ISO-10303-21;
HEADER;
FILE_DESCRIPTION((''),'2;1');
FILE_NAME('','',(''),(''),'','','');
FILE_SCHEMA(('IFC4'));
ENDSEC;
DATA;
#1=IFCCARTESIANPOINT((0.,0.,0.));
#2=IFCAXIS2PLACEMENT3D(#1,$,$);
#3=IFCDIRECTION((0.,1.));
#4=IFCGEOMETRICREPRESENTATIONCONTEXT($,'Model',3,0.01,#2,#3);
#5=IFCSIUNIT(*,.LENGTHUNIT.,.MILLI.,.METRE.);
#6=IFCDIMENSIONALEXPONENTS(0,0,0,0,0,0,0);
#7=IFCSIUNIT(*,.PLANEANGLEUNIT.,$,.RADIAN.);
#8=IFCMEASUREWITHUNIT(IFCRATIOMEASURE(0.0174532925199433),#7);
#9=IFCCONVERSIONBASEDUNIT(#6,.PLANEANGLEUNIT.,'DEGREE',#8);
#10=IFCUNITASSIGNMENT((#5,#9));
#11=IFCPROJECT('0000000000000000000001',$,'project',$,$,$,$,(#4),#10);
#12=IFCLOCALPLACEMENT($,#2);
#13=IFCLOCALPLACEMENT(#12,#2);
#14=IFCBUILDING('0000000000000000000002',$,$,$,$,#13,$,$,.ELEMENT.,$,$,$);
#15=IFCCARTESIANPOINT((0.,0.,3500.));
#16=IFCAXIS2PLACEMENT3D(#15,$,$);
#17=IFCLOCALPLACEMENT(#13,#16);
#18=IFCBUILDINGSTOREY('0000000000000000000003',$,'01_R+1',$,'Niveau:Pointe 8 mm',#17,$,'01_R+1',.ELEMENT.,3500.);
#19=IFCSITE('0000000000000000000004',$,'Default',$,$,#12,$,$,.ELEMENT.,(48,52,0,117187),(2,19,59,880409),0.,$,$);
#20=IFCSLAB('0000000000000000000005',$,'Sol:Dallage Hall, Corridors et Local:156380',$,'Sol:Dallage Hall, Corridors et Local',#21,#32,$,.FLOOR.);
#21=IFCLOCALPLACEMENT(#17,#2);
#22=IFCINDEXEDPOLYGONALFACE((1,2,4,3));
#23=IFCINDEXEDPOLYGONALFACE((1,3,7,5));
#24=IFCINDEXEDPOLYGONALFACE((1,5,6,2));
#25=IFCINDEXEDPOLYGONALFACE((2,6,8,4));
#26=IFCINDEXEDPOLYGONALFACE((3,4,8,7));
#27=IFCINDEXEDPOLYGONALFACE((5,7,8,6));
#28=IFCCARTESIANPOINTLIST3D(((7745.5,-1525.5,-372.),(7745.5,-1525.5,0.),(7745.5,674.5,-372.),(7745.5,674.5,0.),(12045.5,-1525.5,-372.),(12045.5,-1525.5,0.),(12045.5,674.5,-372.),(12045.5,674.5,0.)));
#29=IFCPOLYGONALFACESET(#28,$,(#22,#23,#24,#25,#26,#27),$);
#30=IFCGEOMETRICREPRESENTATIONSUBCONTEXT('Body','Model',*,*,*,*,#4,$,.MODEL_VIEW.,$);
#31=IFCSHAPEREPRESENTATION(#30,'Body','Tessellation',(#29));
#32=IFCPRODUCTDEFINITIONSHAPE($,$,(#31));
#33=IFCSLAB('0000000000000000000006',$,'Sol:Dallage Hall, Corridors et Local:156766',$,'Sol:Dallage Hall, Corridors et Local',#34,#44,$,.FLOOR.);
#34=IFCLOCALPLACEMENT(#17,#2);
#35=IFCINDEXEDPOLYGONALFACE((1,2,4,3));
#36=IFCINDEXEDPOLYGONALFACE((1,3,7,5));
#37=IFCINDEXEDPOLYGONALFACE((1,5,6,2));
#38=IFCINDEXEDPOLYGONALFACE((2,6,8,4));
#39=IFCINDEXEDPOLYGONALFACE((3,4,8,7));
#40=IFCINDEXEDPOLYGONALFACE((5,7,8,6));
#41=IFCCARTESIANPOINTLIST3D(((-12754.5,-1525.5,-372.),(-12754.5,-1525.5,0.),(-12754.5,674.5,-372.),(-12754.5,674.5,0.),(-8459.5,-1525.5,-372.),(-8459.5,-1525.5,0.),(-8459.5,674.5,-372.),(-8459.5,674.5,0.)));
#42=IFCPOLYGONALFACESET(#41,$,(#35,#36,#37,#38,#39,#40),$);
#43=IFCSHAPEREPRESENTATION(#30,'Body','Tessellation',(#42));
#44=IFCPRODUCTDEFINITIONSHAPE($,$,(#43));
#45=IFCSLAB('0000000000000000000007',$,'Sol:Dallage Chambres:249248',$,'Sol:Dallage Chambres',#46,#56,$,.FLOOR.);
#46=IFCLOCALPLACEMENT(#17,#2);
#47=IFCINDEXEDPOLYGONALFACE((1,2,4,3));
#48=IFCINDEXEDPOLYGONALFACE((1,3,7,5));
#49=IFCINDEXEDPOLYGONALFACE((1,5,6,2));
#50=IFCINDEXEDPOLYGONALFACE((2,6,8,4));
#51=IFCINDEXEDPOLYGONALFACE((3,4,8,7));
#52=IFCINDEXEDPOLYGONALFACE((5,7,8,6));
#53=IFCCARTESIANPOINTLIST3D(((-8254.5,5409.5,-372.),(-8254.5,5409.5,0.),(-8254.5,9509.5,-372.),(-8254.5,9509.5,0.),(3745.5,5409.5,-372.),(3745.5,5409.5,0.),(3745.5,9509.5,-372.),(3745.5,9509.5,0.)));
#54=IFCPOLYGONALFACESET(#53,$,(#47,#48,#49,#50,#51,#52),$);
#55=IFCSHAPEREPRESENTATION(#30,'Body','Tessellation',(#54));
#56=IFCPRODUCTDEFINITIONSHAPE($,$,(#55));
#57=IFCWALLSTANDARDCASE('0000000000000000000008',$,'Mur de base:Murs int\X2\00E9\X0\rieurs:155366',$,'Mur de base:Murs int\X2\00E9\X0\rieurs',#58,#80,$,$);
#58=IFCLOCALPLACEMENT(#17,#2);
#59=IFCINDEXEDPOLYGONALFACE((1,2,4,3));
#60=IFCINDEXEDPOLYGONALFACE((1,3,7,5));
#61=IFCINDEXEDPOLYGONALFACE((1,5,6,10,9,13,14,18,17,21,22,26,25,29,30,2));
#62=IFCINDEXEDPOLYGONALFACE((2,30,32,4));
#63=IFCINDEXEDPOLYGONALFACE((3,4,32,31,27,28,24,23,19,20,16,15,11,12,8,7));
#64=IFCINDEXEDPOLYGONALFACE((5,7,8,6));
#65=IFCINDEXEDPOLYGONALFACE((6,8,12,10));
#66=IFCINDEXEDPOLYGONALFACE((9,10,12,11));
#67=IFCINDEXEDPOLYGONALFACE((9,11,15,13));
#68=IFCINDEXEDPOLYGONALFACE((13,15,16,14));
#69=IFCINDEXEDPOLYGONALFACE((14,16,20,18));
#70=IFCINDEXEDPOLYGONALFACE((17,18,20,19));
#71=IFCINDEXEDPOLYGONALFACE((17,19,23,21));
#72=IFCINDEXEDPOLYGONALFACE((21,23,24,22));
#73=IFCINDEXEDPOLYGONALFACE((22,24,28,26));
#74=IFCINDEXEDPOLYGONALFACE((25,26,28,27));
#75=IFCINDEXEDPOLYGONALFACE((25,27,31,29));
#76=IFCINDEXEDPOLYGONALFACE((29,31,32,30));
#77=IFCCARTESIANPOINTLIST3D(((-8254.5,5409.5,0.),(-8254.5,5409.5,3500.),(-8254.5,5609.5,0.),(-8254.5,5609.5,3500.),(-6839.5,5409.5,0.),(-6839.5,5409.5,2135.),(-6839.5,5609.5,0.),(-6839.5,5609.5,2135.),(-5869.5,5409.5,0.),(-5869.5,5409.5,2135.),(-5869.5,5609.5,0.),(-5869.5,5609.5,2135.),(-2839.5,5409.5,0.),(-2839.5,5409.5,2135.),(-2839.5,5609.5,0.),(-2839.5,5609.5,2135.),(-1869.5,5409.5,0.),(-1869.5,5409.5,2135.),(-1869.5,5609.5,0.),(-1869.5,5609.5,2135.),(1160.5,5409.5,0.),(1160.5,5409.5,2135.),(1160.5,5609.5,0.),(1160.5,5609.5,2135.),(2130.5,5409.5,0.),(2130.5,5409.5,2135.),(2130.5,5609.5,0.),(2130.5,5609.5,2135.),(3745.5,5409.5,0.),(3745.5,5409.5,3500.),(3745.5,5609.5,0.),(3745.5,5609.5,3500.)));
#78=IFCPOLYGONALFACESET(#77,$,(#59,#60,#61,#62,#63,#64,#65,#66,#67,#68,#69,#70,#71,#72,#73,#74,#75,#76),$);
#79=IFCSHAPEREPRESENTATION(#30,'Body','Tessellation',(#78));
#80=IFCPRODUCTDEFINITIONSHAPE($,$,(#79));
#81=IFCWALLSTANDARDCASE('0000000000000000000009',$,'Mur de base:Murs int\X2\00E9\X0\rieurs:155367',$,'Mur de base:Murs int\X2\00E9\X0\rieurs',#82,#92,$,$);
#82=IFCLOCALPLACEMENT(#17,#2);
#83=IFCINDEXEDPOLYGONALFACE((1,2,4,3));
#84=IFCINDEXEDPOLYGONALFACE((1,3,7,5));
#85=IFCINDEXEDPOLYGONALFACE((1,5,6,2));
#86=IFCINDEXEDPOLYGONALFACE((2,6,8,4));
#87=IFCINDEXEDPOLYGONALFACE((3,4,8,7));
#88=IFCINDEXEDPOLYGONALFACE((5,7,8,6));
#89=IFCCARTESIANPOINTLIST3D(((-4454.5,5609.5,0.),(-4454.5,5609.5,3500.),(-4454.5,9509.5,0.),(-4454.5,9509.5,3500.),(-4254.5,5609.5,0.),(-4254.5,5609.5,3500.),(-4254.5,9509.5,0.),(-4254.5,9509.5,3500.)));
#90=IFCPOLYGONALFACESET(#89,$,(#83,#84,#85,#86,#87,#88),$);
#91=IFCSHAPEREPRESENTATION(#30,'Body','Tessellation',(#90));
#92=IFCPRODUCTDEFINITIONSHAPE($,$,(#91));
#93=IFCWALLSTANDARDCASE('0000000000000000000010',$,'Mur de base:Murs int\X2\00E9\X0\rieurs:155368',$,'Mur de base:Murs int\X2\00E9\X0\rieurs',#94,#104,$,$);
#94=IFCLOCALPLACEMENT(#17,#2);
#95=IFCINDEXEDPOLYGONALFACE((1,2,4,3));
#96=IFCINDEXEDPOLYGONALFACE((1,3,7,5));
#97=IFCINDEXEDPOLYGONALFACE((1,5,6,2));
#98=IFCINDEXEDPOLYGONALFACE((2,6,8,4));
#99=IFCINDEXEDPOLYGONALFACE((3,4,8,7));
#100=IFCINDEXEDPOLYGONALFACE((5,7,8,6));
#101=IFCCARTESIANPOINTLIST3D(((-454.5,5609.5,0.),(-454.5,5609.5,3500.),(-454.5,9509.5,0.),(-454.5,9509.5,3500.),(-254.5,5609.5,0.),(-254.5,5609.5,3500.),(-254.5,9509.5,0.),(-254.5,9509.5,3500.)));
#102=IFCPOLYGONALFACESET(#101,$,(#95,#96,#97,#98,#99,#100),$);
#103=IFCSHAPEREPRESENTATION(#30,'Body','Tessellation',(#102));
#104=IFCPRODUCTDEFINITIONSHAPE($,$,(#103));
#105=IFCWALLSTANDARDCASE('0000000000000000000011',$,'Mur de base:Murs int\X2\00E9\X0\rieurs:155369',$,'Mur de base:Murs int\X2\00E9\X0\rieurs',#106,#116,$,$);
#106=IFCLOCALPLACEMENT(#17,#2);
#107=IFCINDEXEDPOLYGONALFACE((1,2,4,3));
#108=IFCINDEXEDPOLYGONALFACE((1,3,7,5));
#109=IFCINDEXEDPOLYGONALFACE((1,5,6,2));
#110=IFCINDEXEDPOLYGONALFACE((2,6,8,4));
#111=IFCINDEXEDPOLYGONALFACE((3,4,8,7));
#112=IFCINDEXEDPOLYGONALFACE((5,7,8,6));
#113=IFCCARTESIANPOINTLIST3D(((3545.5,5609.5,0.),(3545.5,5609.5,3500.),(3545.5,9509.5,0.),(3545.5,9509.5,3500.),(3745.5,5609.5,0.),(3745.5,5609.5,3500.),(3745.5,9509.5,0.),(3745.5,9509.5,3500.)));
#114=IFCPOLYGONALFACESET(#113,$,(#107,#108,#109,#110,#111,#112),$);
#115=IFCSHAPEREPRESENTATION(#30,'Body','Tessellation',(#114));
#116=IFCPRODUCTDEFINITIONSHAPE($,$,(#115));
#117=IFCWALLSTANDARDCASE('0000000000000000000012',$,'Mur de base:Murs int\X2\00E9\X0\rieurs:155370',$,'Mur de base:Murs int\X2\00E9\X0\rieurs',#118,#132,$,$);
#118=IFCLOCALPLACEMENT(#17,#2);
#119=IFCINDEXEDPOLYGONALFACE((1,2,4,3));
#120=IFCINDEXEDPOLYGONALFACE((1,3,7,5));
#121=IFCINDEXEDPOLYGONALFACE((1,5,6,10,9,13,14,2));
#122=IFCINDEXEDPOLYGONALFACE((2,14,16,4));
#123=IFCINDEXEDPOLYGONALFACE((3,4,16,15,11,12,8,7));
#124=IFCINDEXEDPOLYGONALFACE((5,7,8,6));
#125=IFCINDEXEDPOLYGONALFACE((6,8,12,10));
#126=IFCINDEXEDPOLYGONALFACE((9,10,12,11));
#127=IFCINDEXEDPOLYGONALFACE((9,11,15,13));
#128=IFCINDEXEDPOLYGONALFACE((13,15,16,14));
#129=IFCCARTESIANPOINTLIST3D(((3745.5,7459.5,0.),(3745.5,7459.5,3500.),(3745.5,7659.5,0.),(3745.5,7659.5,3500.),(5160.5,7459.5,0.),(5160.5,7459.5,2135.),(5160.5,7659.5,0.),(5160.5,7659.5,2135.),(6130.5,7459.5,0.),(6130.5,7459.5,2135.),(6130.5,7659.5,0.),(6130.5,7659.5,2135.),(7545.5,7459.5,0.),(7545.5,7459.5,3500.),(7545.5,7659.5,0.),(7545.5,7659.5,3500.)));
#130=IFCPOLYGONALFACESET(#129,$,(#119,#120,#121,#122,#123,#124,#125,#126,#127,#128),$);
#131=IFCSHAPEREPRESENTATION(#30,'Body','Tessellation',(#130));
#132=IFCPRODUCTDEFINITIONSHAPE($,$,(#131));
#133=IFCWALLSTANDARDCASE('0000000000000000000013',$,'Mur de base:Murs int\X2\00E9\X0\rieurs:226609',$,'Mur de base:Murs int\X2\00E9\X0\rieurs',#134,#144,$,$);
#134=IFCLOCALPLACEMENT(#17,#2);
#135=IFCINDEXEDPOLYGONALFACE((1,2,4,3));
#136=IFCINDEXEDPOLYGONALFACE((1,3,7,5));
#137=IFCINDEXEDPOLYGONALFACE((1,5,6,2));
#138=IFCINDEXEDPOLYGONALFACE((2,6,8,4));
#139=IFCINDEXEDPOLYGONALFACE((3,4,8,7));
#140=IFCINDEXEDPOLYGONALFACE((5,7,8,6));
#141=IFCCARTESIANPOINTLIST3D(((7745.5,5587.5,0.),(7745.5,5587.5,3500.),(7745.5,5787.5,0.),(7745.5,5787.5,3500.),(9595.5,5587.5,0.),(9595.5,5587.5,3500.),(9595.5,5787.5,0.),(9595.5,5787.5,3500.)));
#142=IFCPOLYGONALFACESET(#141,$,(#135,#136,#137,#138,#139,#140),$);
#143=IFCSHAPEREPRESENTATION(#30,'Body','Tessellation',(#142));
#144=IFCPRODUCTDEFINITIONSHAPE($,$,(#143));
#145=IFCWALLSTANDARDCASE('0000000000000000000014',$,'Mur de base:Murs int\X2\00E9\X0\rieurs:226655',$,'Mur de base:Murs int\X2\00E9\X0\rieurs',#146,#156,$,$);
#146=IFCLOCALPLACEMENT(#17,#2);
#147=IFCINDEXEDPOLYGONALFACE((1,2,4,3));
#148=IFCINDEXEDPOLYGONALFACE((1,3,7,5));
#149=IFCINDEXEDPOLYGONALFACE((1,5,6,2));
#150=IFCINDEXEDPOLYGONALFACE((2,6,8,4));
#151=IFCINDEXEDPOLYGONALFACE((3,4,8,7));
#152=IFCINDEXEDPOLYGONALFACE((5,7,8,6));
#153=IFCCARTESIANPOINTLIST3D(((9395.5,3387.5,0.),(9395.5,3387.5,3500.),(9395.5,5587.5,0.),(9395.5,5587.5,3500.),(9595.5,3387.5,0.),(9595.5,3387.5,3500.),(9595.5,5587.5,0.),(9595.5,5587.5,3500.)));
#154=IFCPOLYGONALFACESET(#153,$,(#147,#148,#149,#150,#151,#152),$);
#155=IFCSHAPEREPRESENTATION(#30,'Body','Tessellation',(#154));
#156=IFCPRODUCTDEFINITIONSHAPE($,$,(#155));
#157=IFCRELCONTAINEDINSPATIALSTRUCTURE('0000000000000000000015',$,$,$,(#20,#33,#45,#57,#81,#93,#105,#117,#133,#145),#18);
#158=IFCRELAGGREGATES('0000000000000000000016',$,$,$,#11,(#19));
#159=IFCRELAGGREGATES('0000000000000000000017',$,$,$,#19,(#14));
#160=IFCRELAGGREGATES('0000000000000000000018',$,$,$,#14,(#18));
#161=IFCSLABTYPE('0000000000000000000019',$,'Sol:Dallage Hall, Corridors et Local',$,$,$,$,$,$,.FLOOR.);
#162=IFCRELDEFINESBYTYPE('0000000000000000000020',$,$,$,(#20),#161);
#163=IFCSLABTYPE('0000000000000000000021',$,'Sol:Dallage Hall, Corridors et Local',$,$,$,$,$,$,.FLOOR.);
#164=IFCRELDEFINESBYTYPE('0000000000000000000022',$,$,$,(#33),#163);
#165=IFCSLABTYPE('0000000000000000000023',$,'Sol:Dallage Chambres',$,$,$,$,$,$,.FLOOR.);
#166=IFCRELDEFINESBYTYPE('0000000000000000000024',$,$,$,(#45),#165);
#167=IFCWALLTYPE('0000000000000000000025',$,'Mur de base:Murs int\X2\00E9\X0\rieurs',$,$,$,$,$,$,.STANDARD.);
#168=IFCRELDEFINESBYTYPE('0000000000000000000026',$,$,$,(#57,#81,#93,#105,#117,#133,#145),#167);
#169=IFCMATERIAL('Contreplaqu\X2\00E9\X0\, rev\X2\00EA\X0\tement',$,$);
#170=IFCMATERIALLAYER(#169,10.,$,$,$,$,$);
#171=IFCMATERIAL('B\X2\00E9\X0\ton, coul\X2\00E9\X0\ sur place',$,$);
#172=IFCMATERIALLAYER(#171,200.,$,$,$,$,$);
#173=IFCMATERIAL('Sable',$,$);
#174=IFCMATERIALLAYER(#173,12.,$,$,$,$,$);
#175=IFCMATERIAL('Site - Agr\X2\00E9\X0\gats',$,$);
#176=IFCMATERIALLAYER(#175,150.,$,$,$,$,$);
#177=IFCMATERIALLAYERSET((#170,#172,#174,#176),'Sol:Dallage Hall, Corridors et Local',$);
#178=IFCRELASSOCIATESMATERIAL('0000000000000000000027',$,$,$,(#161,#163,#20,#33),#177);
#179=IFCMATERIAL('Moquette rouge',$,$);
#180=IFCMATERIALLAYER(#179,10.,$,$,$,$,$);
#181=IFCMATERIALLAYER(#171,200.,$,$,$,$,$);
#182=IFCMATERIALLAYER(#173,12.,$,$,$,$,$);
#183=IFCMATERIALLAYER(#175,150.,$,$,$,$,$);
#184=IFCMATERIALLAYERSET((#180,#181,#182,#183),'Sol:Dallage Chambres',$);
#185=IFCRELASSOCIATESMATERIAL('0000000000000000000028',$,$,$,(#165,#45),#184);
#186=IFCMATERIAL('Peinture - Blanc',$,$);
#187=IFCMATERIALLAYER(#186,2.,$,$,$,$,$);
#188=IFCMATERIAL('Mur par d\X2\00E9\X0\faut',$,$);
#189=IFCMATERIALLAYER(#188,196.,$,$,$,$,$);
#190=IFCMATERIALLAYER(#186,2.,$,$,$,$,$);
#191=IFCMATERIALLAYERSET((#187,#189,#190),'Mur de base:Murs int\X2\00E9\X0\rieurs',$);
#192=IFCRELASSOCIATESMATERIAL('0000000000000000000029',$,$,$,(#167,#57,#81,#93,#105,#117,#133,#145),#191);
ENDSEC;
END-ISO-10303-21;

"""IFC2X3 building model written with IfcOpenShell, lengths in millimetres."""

from ifc_helpers import new_model, entity, si_unit, converted_unit, direction, frame, frame_2d, origin, place, context, subcontext, project, spatial, rectangle, extrude, material, layer, layer_set, layer_usage, type_object, element, save


model = new_model("IFC2X3")

# Units and contexts
model_context = context("Model", 3, precision=0.01, world=origin(), true_north=direction((0.0, 1.0)))
body_context = subcontext(model_context, "Body", "Model", "MODEL_VIEW")
ifc_project = project(units=[si_unit("LENGTHUNIT", "METRE", prefix="MILLI"), converted_unit("PLANEANGLEUNIT", "DEGREE", entity("IfcRatioMeasure", 0.0174532925199433), si_unit("PLANEANGLEUNIT", "RADIAN"), dimensions=[0, 0, 0, 0, 0, 0, 0])], contexts=[model_context])

# Site, building, storey
site_placement = place(None, origin())
site = spatial("IfcSite", under=ifc_project, at=site_placement, Name="Default", CompositionType="ELEMENT", RefLatitude=(48, 52, 0, 117187), RefLongitude=(2, 19, 59, 880409), RefElevation=0.0)
building_placement = place(site_placement, origin())
building = spatial("IfcBuilding", under=site, at=building_placement, CompositionType="ELEMENT")
storey_placement = place(building_placement, frame((0.0, 0.0, 3500.0)))
storey = spatial("IfcBuildingStorey", under=building, at=storey_placement, Name="01_R+1", ObjectType="Niveau:Pointe 8 mm", LongName="01_R+1", CompositionType="ELEMENT", Elevation=3500.0)

# Slabs
ifc_material_1 = material(Name="Contreplaqué, revêtement")
ifc_layer_1 = layer(ifc_material_1, 10.0)
ifc_material_2 = material(Name="Béton, coulé sur place")
ifc_layer_2 = layer(ifc_material_2, 200.0)
ifc_material_3 = material(Name="Sable")
ifc_layer_3 = layer(ifc_material_3, 12.0)
ifc_material_4 = material(Name="Site - Agrégats")
ifc_layer_4 = layer(ifc_material_4, 150.0)
ifc_layer_set_1 = layer_set([ifc_layer_1, ifc_layer_2, ifc_layer_3, ifc_layer_4], Name="Sol:Dallage Hall, Corridors et Local")
ifc_layer_usage_1 = layer_usage(ifc_layer_set_1, "AXIS3", "POSITIVE", 0.0)
slab_type_1 = type_object("IfcSlabType", Name="Sol:Dallage Hall, Corridors et Local", PredefinedType="FLOOR", material=ifc_layer_set_1)
slab_1_placement = place(storey_placement, origin())
element("IfcSlab", 1, at=slab_1_placement, inside=storey, type_object=slab_type_1, material=ifc_layer_usage_1, Name="Sol:Dallage Hall, Corridors et Local:156380", ObjectType="Sol:Dallage Hall, Corridors et Local", PredefinedType="FLOOR", context=body_context, shape_type="SweptSolid", body=[
    extrude(rectangle(XDim=2200.0, YDim=4300.0, at=frame_2d((0.0, 0.0), x_axis=(1.0, 0.0))), frame((9895.5, -425.5, 0.0), z_axis=(0.0, 0.0, -1.0), x_axis=(0.0, 1.0, 0.0)), (0.0, 0.0, 1.0), 372.0),
])
ifc_layer_usage_2 = layer_usage(ifc_layer_set_1, "AXIS3", "POSITIVE", 0.0)
slab_type_2 = type_object("IfcSlabType", Name="Sol:Dallage Hall, Corridors et Local", PredefinedType="FLOOR", material=ifc_layer_set_1)
slab_2_placement = place(storey_placement, origin())
element("IfcSlab", 2, at=slab_2_placement, inside=storey, type_object=slab_type_2, material=ifc_layer_usage_2, Name="Sol:Dallage Hall, Corridors et Local:156766", ObjectType="Sol:Dallage Hall, Corridors et Local", PredefinedType="FLOOR", context=body_context, shape_type="SweptSolid", body=[
    extrude(rectangle(XDim=2200.0, YDim=4295.0, at=frame_2d((0.0, 0.0), x_axis=(1.0, 0.0))), frame((-10607.0, -425.5, 0.0), z_axis=(0.0, 0.0, -1.0), x_axis=(0.0, 1.0, 0.0)), (0.0, 0.0, 1.0), 372.0),
])
ifc_material_5 = material(Name="Moquette rouge")
ifc_layer_5 = layer(ifc_material_5, 10.0)
ifc_layer_6 = layer(ifc_material_2, 200.0)
ifc_layer_7 = layer(ifc_material_3, 12.0)
ifc_layer_8 = layer(ifc_material_4, 150.0)
ifc_layer_set_2 = layer_set([ifc_layer_5, ifc_layer_6, ifc_layer_7, ifc_layer_8], Name="Sol:Dallage Chambres")
ifc_layer_usage_3 = layer_usage(ifc_layer_set_2, "AXIS3", "POSITIVE", 0.0)
slab_type_3 = type_object("IfcSlabType", Name="Sol:Dallage Chambres", PredefinedType="FLOOR", material=ifc_layer_set_2)
slab_3_placement = place(storey_placement, origin())
element("IfcSlab", 3, at=slab_3_placement, inside=storey, type_object=slab_type_3, material=ifc_layer_usage_3, Name="Sol:Dallage Chambres:249248", ObjectType="Sol:Dallage Chambres", PredefinedType="FLOOR", context=body_context, shape_type="SweptSolid", body=[
    extrude(rectangle(XDim=4100.0, YDim=12000.0, at=frame_2d((0.0, 0.0), x_axis=(1.0, 0.0))), frame((-2254.5, 7459.5, 0.0), z_axis=(0.0, 0.0, -1.0), x_axis=(0.0, 1.0, 0.0)), (0.0, 0.0, 1.0), 372.0),
])

# Wall, openings
ifc_material_6 = material(Name="Peinture - Blanc")
ifc_layer_9 = layer(ifc_material_6, 2.0)
ifc_material_7 = material(Name="Mur par défaut")
ifc_layer_10 = layer(ifc_material_7, 196.0)
ifc_layer_11 = layer(ifc_material_6, 2.0)
ifc_layer_set_3 = layer_set([ifc_layer_9, ifc_layer_10, ifc_layer_11], Name="Mur de base:Murs intérieurs")
ifc_layer_usage_4 = layer_usage(ifc_layer_set_3, "AXIS2", "NEGATIVE", 100.0)
wall_type_1 = type_object("IfcWallType", Name="Mur de base:Murs intérieurs", PredefinedType="STANDARD", material=ifc_layer_set_3)
wall_1_placement = place(storey_placement, frame((-8254.5, 5509.5, 0.0)))
wall_1 = element("IfcWallStandardCase", 4, at=wall_1_placement, inside=storey, type_object=wall_type_1, material=ifc_layer_usage_4, Name="Mur de base:Murs intérieurs:155366", ObjectType="Mur de base:Murs intérieurs", context=body_context, shape_type="SweptSolid", body=[
    extrude(rectangle(XDim=12000.0, YDim=200.0, at=frame_2d((6000.0, 0.0), x_axis=(-1.0, 0.0))), origin(), (0.0, 0.0, 1.0), 3500.0),
])
opening_1_placement = place(wall_1_placement, frame((1415.0, -100.0, 0.0)))
element("IfcOpeningElement", 5, at=opening_1_placement, cuts=wall_1, ObjectType="Opening", context=body_context, shape_type="SweptSolid", body=[
    extrude(rectangle(XDim=2135.0, YDim=970.0, at=frame_2d((1067.5, 485.0), x_axis=(1.0, 0.0))), frame((0.0, 0.0, 0.0), z_axis=(0.0, 1.0, 0.0), x_axis=(0.0, 0.0, 1.0)), (0.0, 0.0, 1.0), 200.0),
])
opening_2_placement = place(wall_1_placement, frame((5415.0, -100.0, 0.0)))
element("IfcOpeningElement", 6, at=opening_2_placement, cuts=wall_1, ObjectType="Opening", context=body_context, shape_type="SweptSolid", body=[
    extrude(rectangle(XDim=2135.0, YDim=970.0, at=frame_2d((1067.5, 485.0), x_axis=(1.0, 0.0))), frame((0.0, 0.0, 0.0), z_axis=(0.0, 1.0, 0.0), x_axis=(0.0, 0.0, 1.0)), (0.0, 0.0, 1.0), 200.0),
])
opening_3_placement = place(wall_1_placement, frame((9415.0, -100.0, 0.0)))
element("IfcOpeningElement", 7, at=opening_3_placement, cuts=wall_1, ObjectType="Opening", context=body_context, shape_type="SweptSolid", body=[
    extrude(rectangle(XDim=2135.0, YDim=970.0, at=frame_2d((1067.5, 485.0), x_axis=(1.0, 0.0))), frame((0.0, 0.0, 0.0), z_axis=(0.0, 1.0, 0.0), x_axis=(0.0, 0.0, 1.0)), (0.0, 0.0, 1.0), 200.0),
])

# Walls
ifc_layer_usage_5 = layer_usage(ifc_layer_set_3, "AXIS2", "NEGATIVE", 100.0)
wall_2_placement = place(storey_placement, frame((-4354.5, 5609.5, 0.0), z_axis=(0.0, 0.0, 1.0), x_axis=(0.0, 1.0, 0.0)))
element("IfcWallStandardCase", 8, at=wall_2_placement, inside=storey, type_object=wall_type_1, material=ifc_layer_usage_5, Name="Mur de base:Murs intérieurs:155367", ObjectType="Mur de base:Murs intérieurs", context=body_context, shape_type="SweptSolid", body=[
    extrude(rectangle(XDim=3900.0, YDim=200.0, at=frame_2d((1950.0, 0.0), x_axis=(-1.0, 0.0))), origin(), (0.0, 0.0, 1.0), 3500.0),
])
ifc_layer_usage_6 = layer_usage(ifc_layer_set_3, "AXIS2", "NEGATIVE", 100.0)
wall_3_placement = place(storey_placement, frame((-354.5, 5609.5, 0.0), z_axis=(0.0, 0.0, 1.0), x_axis=(0.0, 1.0, 0.0)))
element("IfcWallStandardCase", 9, at=wall_3_placement, inside=storey, type_object=wall_type_1, material=ifc_layer_usage_6, Name="Mur de base:Murs intérieurs:155368", ObjectType="Mur de base:Murs intérieurs", context=body_context, shape_type="SweptSolid", body=[
    extrude(rectangle(XDim=3900.0, YDim=200.0, at=frame_2d((1950.0, 0.0), x_axis=(-1.0, 0.0))), origin(), (0.0, 0.0, 1.0), 3500.0),
])
ifc_layer_usage_7 = layer_usage(ifc_layer_set_3, "AXIS2", "NEGATIVE", 100.0)
wall_4_placement = place(storey_placement, frame((3645.5, 5609.5, 0.0), z_axis=(0.0, 0.0, 1.0), x_axis=(0.0, 1.0, 0.0)))
element("IfcWallStandardCase", 10, at=wall_4_placement, inside=storey, type_object=wall_type_1, material=ifc_layer_usage_7, Name="Mur de base:Murs intérieurs:155369", ObjectType="Mur de base:Murs intérieurs", context=body_context, shape_type="SweptSolid", body=[
    extrude(rectangle(XDim=3900.0, YDim=200.0, at=frame_2d((1950.0, 0.0), x_axis=(-1.0, 0.0))), origin(), (0.0, 0.0, 1.0), 3500.0),
])

# Wall, opening
ifc_layer_usage_8 = layer_usage(ifc_layer_set_3, "AXIS2", "NEGATIVE", 100.0)
wall_5_placement = place(storey_placement, frame((3745.5, 7559.5, 0.0)))
wall_5 = element("IfcWallStandardCase", 11, at=wall_5_placement, inside=storey, type_object=wall_type_1, material=ifc_layer_usage_8, Name="Mur de base:Murs intérieurs:155370", ObjectType="Mur de base:Murs intérieurs", context=body_context, shape_type="SweptSolid", body=[
    extrude(rectangle(XDim=3800.0, YDim=200.0, at=frame_2d((1900.0, 0.0), x_axis=(-1.0, 0.0))), origin(), (0.0, 0.0, 1.0), 3500.0),
])
opening_4_placement = place(wall_5_placement, frame((1415.0, -100.0, 0.0)))
element("IfcOpeningElement", 12, at=opening_4_placement, cuts=wall_5, ObjectType="Opening", context=body_context, shape_type="SweptSolid", body=[
    extrude(rectangle(XDim=2135.0, YDim=970.0, at=frame_2d((1067.5, 485.0), x_axis=(1.0, 0.0))), frame((0.0, 0.0, 0.0), z_axis=(0.0, 1.0, 0.0), x_axis=(0.0, 0.0, 1.0)), (0.0, 0.0, 1.0), 200.0),
])

# Walls
ifc_layer_usage_9 = layer_usage(ifc_layer_set_3, "AXIS2", "NEGATIVE", 100.0)
wall_6_placement = place(storey_placement, frame((7745.5, 5687.5, 0.0)))
element("IfcWallStandardCase", 13, at=wall_6_placement, inside=storey, type_object=wall_type_1, material=ifc_layer_usage_9, Name="Mur de base:Murs intérieurs:226609", ObjectType="Mur de base:Murs intérieurs", context=body_context, shape_type="SweptSolid", body=[
    extrude(rectangle(XDim=1850.0, YDim=200.0, at=frame_2d((925.0, 0.0), x_axis=(-1.0, 0.0))), origin(), (0.0, 0.0, 1.0), 3500.0),
])
ifc_layer_usage_10 = layer_usage(ifc_layer_set_3, "AXIS2", "NEGATIVE", 100.0)
wall_7_placement = place(storey_placement, frame((9495.5, 5587.5, 0.0), z_axis=(0.0, 0.0, 1.0), x_axis=(0.0, -1.0, 0.0)))
element("IfcWallStandardCase", 14, at=wall_7_placement, inside=storey, type_object=wall_type_1, material=ifc_layer_usage_10, Name="Mur de base:Murs intérieurs:226655", ObjectType="Mur de base:Murs intérieurs", context=body_context, shape_type="SweptSolid", body=[
    extrude(rectangle(XDim=2200.0, YDim=200.0, at=frame_2d((1100.0, 0.0), x_axis=(-1.0, 0.0))), origin(), (0.0, 0.0, 1.0), 3500.0),
])

save(model, "model.ifc")
